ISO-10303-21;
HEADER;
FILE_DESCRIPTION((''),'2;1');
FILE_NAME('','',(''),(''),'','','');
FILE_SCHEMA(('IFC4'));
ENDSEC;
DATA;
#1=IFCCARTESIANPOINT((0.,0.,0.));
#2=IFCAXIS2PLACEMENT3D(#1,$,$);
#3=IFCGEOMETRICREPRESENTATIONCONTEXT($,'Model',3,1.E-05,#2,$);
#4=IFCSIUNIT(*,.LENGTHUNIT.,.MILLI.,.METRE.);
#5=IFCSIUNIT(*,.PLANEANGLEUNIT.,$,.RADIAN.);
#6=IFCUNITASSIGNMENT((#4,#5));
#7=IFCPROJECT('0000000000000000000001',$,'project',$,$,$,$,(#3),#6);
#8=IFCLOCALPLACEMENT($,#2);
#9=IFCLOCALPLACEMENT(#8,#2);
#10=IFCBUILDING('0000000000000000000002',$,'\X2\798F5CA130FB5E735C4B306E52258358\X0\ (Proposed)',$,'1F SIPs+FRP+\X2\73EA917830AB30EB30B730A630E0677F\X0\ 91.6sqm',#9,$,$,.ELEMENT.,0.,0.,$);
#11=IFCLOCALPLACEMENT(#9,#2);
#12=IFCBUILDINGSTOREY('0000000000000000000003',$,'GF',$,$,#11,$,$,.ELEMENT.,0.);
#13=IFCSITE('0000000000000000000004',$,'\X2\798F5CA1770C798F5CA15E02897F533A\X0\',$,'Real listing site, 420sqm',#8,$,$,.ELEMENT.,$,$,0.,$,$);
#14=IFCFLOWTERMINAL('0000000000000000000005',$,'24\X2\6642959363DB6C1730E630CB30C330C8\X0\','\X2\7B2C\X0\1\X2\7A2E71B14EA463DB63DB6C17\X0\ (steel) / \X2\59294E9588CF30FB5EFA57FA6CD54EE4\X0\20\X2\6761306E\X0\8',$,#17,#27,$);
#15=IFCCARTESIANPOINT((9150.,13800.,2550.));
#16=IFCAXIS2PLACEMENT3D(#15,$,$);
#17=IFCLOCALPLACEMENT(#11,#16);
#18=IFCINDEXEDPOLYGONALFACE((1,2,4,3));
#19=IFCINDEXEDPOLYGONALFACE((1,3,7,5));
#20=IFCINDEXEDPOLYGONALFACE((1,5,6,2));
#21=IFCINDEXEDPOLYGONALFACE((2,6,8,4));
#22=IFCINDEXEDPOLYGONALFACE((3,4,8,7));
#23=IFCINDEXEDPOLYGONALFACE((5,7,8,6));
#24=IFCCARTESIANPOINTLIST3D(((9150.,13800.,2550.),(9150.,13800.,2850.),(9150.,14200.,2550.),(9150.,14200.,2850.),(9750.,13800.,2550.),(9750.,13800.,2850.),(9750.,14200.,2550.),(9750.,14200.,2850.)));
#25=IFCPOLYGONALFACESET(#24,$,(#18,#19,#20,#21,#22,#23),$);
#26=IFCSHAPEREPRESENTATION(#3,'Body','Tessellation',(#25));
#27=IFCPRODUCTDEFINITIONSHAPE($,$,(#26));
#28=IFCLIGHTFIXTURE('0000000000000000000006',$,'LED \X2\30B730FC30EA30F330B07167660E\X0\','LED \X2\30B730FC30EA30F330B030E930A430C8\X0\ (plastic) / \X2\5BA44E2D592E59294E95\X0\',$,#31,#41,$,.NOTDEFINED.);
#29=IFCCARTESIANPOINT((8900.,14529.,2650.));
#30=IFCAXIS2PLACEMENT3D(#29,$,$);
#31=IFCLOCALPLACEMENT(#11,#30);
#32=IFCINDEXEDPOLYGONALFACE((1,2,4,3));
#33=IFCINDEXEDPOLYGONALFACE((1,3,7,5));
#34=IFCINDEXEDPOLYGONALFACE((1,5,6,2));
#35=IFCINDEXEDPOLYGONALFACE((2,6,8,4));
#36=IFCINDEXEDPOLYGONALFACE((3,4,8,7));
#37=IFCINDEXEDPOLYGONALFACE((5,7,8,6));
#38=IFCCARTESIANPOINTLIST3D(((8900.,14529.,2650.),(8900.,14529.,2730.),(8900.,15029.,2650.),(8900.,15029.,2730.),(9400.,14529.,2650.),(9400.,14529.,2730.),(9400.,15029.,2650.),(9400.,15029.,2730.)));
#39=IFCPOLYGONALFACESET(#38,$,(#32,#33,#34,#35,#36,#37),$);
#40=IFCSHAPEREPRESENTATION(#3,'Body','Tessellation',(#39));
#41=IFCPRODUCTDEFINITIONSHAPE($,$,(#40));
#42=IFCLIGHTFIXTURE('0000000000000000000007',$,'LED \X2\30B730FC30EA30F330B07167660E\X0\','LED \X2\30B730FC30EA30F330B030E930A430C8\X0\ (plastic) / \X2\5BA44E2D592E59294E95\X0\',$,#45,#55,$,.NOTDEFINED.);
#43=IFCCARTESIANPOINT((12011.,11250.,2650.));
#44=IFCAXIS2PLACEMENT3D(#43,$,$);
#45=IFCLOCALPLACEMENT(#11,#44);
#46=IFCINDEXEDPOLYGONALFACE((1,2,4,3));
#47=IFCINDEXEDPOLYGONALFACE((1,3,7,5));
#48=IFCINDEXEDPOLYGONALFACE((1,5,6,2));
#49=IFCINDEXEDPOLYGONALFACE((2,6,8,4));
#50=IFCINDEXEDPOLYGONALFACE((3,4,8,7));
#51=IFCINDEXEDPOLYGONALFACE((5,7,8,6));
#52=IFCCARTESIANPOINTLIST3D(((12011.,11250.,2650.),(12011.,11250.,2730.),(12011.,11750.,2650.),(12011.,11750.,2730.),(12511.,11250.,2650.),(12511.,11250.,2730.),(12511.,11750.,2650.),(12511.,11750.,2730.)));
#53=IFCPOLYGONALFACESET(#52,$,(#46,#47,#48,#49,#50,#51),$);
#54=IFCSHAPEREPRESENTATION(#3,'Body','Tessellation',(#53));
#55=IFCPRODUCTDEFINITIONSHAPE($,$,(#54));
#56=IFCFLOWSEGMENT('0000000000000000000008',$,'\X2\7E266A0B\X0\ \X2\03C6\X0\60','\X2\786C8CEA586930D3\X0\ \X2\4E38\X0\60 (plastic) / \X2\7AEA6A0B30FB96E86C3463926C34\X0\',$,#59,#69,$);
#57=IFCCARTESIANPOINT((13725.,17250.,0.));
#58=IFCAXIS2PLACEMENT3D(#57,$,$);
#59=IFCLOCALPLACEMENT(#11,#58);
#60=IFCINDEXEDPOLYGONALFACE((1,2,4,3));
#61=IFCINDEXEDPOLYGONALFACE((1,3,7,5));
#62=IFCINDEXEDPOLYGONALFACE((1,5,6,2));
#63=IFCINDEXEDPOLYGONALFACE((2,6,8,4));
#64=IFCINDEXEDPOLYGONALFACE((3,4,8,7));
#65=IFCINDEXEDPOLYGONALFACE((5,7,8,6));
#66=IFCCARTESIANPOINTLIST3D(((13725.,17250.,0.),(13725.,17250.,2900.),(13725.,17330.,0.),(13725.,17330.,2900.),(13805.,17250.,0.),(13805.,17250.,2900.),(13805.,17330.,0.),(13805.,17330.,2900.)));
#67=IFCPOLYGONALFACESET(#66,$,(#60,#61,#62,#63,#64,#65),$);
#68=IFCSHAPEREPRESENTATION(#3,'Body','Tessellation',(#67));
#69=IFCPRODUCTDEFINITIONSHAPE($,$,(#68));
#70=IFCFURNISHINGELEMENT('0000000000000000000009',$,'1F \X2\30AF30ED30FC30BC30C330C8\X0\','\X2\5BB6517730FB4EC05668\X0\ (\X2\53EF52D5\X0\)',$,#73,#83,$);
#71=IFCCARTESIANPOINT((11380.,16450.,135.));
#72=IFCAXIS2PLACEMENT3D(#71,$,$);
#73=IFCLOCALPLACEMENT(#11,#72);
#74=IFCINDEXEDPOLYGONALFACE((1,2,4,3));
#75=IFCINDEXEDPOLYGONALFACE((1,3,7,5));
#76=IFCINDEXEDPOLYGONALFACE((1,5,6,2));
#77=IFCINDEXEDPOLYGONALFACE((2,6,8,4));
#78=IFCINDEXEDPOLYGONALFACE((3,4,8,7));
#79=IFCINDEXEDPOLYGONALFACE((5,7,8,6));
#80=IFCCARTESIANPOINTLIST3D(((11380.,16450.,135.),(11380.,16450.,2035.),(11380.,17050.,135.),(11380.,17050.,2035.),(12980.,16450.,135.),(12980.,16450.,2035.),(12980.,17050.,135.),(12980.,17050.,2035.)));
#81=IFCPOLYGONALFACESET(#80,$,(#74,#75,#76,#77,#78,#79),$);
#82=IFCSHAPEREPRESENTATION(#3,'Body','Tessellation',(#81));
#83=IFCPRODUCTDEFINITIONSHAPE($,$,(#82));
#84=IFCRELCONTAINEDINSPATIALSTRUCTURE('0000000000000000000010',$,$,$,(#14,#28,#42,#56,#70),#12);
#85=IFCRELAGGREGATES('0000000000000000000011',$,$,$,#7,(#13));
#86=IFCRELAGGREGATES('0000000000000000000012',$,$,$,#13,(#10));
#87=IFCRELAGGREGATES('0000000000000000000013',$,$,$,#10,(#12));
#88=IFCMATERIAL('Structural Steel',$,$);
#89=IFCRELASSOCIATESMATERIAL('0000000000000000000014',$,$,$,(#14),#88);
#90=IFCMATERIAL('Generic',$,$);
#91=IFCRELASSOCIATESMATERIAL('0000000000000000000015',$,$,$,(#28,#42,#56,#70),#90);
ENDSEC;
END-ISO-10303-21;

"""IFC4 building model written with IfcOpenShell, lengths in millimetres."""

from ifc_helpers import new_model, si_unit, frame, frame_2d, origin, place, context, project, spatial, rectangle, extrude, material, element, save


model = new_model("IFC4")

# Units and contexts
model_context = context("Model", 3, precision=1e-05, world=origin())
ifc_project = project(units=[si_unit("LENGTHUNIT", "METRE", prefix="MILLI"), si_unit("PLANEANGLEUNIT", "RADIAN")], contexts=[model_context])

# Site, building, storey
site_placement = place(None, origin())
site = spatial("IfcSite", under=ifc_project, at=site_placement, Name="福岡県福岡市西区", ObjectType="Real listing site, 420sqm", CompositionType="ELEMENT", RefElevation=0.0)
building_placement = place(site_placement, origin())
building = spatial("IfcBuilding", under=site, at=building_placement, Name="福岡・平屋の別荘 (Proposed)", ObjectType="1F SIPs+FRP+珪酸カルシウム板 91.6sqm", CompositionType="ELEMENT", ElevationOfRefHeight=0.0, ElevationOfTerrain=0.0)
storey_placement = place(building_placement, origin())
storey = spatial("IfcBuildingStorey", under=building, at=storey_placement, Name="GF", CompositionType="ELEMENT", Elevation=0.0)

# Shared definitions
ifc_material_1 = material(Name="Generic")

# Flow terminal
ifc_material_2 = material(Name="Structural Steel")
flow_terminal_placement = place(storey_placement, frame((9150.0, 13800.0, 2550.0)))
element("IfcFlowTerminal", 1, at=flow_terminal_placement, inside=storey, material=ifc_material_2, Name="24時間換気ユニット", Description="第1種熱交換換気 (steel) / 天井裏・建基法令20条の8", context=model_context, shape_type="SweptSolid", body=[
    extrude(rectangle(XDim=600.0, YDim=400.0, at=frame_2d((300.0, 200.0))), frame((9150.0, 13800.0, 2550.0)), (0.0, 0.0, 1.0), 300.0),
])

# Light fixtures
light_fixture_1_placement = place(storey_placement, frame((8900.0, 14529.0, 2650.0)))
element("IfcLightFixture", 2, at=light_fixture_1_placement, inside=storey, material=ifc_material_1, Name="LED シーリング照明", Description="LED シーリングライト (plastic) / 室中央天井", PredefinedType="NOTDEFINED", context=model_context, shape_type="SweptSolid", body=[
    extrude(rectangle(XDim=500.0, YDim=500.0, at=frame_2d((250.0, 250.0))), frame((8900.0, 14529.0, 2650.0)), (0.0, 0.0, 1.0), 80.0),
])
light_fixture_2_placement = place(storey_placement, frame((12011.0, 11250.0, 2650.0)))
element("IfcLightFixture", 3, at=light_fixture_2_placement, inside=storey, material=ifc_material_1, Name="LED シーリング照明", Description="LED シーリングライト (plastic) / 室中央天井", PredefinedType="NOTDEFINED", context=model_context, shape_type="SweptSolid", body=[
    extrude(rectangle(XDim=500.0, YDim=500.0, at=frame_2d((250.0, 250.0))), frame((12011.0, 11250.0, 2650.0)), (0.0, 0.0, 1.0), 80.0),
])

# Flow segment
flow_segment_placement = place(storey_placement, frame((13725.0, 17250.0, 0.0)))
element("IfcFlowSegment", 4, at=flow_segment_placement, inside=storey, material=ifc_material_1, Name="縦樋 φ60", Description="硬質塩ビ 丸60 (plastic) / 竪樋・雨水排水", context=model_context, shape_type="SweptSolid", body=[
    extrude(rectangle(XDim=80.0, YDim=80.0, at=frame_2d((40.0, 40.0))), frame((13725.0, 17250.0, 0.0)), (0.0, 0.0, 1.0), 2900.0),
])

# Furnishing element
furnishing_placement = place(storey_placement, frame((11380.0, 16450.0, 135.0)))
element("IfcFurnishingElement", 5, at=furnishing_placement, inside=storey, material=ifc_material_1, Name="1F クローゼット", Description="家具・什器 (可動)", context=model_context, shape_type="SweptSolid", body=[
    extrude(rectangle(XDim=1600.0, YDim=600.0, at=frame_2d((800.0, 300.0))), frame((11380.0, 16450.0, 135.0)), (0.0, 0.0, 1.0), 1900.0),
])

save(model, "model.ifc")
